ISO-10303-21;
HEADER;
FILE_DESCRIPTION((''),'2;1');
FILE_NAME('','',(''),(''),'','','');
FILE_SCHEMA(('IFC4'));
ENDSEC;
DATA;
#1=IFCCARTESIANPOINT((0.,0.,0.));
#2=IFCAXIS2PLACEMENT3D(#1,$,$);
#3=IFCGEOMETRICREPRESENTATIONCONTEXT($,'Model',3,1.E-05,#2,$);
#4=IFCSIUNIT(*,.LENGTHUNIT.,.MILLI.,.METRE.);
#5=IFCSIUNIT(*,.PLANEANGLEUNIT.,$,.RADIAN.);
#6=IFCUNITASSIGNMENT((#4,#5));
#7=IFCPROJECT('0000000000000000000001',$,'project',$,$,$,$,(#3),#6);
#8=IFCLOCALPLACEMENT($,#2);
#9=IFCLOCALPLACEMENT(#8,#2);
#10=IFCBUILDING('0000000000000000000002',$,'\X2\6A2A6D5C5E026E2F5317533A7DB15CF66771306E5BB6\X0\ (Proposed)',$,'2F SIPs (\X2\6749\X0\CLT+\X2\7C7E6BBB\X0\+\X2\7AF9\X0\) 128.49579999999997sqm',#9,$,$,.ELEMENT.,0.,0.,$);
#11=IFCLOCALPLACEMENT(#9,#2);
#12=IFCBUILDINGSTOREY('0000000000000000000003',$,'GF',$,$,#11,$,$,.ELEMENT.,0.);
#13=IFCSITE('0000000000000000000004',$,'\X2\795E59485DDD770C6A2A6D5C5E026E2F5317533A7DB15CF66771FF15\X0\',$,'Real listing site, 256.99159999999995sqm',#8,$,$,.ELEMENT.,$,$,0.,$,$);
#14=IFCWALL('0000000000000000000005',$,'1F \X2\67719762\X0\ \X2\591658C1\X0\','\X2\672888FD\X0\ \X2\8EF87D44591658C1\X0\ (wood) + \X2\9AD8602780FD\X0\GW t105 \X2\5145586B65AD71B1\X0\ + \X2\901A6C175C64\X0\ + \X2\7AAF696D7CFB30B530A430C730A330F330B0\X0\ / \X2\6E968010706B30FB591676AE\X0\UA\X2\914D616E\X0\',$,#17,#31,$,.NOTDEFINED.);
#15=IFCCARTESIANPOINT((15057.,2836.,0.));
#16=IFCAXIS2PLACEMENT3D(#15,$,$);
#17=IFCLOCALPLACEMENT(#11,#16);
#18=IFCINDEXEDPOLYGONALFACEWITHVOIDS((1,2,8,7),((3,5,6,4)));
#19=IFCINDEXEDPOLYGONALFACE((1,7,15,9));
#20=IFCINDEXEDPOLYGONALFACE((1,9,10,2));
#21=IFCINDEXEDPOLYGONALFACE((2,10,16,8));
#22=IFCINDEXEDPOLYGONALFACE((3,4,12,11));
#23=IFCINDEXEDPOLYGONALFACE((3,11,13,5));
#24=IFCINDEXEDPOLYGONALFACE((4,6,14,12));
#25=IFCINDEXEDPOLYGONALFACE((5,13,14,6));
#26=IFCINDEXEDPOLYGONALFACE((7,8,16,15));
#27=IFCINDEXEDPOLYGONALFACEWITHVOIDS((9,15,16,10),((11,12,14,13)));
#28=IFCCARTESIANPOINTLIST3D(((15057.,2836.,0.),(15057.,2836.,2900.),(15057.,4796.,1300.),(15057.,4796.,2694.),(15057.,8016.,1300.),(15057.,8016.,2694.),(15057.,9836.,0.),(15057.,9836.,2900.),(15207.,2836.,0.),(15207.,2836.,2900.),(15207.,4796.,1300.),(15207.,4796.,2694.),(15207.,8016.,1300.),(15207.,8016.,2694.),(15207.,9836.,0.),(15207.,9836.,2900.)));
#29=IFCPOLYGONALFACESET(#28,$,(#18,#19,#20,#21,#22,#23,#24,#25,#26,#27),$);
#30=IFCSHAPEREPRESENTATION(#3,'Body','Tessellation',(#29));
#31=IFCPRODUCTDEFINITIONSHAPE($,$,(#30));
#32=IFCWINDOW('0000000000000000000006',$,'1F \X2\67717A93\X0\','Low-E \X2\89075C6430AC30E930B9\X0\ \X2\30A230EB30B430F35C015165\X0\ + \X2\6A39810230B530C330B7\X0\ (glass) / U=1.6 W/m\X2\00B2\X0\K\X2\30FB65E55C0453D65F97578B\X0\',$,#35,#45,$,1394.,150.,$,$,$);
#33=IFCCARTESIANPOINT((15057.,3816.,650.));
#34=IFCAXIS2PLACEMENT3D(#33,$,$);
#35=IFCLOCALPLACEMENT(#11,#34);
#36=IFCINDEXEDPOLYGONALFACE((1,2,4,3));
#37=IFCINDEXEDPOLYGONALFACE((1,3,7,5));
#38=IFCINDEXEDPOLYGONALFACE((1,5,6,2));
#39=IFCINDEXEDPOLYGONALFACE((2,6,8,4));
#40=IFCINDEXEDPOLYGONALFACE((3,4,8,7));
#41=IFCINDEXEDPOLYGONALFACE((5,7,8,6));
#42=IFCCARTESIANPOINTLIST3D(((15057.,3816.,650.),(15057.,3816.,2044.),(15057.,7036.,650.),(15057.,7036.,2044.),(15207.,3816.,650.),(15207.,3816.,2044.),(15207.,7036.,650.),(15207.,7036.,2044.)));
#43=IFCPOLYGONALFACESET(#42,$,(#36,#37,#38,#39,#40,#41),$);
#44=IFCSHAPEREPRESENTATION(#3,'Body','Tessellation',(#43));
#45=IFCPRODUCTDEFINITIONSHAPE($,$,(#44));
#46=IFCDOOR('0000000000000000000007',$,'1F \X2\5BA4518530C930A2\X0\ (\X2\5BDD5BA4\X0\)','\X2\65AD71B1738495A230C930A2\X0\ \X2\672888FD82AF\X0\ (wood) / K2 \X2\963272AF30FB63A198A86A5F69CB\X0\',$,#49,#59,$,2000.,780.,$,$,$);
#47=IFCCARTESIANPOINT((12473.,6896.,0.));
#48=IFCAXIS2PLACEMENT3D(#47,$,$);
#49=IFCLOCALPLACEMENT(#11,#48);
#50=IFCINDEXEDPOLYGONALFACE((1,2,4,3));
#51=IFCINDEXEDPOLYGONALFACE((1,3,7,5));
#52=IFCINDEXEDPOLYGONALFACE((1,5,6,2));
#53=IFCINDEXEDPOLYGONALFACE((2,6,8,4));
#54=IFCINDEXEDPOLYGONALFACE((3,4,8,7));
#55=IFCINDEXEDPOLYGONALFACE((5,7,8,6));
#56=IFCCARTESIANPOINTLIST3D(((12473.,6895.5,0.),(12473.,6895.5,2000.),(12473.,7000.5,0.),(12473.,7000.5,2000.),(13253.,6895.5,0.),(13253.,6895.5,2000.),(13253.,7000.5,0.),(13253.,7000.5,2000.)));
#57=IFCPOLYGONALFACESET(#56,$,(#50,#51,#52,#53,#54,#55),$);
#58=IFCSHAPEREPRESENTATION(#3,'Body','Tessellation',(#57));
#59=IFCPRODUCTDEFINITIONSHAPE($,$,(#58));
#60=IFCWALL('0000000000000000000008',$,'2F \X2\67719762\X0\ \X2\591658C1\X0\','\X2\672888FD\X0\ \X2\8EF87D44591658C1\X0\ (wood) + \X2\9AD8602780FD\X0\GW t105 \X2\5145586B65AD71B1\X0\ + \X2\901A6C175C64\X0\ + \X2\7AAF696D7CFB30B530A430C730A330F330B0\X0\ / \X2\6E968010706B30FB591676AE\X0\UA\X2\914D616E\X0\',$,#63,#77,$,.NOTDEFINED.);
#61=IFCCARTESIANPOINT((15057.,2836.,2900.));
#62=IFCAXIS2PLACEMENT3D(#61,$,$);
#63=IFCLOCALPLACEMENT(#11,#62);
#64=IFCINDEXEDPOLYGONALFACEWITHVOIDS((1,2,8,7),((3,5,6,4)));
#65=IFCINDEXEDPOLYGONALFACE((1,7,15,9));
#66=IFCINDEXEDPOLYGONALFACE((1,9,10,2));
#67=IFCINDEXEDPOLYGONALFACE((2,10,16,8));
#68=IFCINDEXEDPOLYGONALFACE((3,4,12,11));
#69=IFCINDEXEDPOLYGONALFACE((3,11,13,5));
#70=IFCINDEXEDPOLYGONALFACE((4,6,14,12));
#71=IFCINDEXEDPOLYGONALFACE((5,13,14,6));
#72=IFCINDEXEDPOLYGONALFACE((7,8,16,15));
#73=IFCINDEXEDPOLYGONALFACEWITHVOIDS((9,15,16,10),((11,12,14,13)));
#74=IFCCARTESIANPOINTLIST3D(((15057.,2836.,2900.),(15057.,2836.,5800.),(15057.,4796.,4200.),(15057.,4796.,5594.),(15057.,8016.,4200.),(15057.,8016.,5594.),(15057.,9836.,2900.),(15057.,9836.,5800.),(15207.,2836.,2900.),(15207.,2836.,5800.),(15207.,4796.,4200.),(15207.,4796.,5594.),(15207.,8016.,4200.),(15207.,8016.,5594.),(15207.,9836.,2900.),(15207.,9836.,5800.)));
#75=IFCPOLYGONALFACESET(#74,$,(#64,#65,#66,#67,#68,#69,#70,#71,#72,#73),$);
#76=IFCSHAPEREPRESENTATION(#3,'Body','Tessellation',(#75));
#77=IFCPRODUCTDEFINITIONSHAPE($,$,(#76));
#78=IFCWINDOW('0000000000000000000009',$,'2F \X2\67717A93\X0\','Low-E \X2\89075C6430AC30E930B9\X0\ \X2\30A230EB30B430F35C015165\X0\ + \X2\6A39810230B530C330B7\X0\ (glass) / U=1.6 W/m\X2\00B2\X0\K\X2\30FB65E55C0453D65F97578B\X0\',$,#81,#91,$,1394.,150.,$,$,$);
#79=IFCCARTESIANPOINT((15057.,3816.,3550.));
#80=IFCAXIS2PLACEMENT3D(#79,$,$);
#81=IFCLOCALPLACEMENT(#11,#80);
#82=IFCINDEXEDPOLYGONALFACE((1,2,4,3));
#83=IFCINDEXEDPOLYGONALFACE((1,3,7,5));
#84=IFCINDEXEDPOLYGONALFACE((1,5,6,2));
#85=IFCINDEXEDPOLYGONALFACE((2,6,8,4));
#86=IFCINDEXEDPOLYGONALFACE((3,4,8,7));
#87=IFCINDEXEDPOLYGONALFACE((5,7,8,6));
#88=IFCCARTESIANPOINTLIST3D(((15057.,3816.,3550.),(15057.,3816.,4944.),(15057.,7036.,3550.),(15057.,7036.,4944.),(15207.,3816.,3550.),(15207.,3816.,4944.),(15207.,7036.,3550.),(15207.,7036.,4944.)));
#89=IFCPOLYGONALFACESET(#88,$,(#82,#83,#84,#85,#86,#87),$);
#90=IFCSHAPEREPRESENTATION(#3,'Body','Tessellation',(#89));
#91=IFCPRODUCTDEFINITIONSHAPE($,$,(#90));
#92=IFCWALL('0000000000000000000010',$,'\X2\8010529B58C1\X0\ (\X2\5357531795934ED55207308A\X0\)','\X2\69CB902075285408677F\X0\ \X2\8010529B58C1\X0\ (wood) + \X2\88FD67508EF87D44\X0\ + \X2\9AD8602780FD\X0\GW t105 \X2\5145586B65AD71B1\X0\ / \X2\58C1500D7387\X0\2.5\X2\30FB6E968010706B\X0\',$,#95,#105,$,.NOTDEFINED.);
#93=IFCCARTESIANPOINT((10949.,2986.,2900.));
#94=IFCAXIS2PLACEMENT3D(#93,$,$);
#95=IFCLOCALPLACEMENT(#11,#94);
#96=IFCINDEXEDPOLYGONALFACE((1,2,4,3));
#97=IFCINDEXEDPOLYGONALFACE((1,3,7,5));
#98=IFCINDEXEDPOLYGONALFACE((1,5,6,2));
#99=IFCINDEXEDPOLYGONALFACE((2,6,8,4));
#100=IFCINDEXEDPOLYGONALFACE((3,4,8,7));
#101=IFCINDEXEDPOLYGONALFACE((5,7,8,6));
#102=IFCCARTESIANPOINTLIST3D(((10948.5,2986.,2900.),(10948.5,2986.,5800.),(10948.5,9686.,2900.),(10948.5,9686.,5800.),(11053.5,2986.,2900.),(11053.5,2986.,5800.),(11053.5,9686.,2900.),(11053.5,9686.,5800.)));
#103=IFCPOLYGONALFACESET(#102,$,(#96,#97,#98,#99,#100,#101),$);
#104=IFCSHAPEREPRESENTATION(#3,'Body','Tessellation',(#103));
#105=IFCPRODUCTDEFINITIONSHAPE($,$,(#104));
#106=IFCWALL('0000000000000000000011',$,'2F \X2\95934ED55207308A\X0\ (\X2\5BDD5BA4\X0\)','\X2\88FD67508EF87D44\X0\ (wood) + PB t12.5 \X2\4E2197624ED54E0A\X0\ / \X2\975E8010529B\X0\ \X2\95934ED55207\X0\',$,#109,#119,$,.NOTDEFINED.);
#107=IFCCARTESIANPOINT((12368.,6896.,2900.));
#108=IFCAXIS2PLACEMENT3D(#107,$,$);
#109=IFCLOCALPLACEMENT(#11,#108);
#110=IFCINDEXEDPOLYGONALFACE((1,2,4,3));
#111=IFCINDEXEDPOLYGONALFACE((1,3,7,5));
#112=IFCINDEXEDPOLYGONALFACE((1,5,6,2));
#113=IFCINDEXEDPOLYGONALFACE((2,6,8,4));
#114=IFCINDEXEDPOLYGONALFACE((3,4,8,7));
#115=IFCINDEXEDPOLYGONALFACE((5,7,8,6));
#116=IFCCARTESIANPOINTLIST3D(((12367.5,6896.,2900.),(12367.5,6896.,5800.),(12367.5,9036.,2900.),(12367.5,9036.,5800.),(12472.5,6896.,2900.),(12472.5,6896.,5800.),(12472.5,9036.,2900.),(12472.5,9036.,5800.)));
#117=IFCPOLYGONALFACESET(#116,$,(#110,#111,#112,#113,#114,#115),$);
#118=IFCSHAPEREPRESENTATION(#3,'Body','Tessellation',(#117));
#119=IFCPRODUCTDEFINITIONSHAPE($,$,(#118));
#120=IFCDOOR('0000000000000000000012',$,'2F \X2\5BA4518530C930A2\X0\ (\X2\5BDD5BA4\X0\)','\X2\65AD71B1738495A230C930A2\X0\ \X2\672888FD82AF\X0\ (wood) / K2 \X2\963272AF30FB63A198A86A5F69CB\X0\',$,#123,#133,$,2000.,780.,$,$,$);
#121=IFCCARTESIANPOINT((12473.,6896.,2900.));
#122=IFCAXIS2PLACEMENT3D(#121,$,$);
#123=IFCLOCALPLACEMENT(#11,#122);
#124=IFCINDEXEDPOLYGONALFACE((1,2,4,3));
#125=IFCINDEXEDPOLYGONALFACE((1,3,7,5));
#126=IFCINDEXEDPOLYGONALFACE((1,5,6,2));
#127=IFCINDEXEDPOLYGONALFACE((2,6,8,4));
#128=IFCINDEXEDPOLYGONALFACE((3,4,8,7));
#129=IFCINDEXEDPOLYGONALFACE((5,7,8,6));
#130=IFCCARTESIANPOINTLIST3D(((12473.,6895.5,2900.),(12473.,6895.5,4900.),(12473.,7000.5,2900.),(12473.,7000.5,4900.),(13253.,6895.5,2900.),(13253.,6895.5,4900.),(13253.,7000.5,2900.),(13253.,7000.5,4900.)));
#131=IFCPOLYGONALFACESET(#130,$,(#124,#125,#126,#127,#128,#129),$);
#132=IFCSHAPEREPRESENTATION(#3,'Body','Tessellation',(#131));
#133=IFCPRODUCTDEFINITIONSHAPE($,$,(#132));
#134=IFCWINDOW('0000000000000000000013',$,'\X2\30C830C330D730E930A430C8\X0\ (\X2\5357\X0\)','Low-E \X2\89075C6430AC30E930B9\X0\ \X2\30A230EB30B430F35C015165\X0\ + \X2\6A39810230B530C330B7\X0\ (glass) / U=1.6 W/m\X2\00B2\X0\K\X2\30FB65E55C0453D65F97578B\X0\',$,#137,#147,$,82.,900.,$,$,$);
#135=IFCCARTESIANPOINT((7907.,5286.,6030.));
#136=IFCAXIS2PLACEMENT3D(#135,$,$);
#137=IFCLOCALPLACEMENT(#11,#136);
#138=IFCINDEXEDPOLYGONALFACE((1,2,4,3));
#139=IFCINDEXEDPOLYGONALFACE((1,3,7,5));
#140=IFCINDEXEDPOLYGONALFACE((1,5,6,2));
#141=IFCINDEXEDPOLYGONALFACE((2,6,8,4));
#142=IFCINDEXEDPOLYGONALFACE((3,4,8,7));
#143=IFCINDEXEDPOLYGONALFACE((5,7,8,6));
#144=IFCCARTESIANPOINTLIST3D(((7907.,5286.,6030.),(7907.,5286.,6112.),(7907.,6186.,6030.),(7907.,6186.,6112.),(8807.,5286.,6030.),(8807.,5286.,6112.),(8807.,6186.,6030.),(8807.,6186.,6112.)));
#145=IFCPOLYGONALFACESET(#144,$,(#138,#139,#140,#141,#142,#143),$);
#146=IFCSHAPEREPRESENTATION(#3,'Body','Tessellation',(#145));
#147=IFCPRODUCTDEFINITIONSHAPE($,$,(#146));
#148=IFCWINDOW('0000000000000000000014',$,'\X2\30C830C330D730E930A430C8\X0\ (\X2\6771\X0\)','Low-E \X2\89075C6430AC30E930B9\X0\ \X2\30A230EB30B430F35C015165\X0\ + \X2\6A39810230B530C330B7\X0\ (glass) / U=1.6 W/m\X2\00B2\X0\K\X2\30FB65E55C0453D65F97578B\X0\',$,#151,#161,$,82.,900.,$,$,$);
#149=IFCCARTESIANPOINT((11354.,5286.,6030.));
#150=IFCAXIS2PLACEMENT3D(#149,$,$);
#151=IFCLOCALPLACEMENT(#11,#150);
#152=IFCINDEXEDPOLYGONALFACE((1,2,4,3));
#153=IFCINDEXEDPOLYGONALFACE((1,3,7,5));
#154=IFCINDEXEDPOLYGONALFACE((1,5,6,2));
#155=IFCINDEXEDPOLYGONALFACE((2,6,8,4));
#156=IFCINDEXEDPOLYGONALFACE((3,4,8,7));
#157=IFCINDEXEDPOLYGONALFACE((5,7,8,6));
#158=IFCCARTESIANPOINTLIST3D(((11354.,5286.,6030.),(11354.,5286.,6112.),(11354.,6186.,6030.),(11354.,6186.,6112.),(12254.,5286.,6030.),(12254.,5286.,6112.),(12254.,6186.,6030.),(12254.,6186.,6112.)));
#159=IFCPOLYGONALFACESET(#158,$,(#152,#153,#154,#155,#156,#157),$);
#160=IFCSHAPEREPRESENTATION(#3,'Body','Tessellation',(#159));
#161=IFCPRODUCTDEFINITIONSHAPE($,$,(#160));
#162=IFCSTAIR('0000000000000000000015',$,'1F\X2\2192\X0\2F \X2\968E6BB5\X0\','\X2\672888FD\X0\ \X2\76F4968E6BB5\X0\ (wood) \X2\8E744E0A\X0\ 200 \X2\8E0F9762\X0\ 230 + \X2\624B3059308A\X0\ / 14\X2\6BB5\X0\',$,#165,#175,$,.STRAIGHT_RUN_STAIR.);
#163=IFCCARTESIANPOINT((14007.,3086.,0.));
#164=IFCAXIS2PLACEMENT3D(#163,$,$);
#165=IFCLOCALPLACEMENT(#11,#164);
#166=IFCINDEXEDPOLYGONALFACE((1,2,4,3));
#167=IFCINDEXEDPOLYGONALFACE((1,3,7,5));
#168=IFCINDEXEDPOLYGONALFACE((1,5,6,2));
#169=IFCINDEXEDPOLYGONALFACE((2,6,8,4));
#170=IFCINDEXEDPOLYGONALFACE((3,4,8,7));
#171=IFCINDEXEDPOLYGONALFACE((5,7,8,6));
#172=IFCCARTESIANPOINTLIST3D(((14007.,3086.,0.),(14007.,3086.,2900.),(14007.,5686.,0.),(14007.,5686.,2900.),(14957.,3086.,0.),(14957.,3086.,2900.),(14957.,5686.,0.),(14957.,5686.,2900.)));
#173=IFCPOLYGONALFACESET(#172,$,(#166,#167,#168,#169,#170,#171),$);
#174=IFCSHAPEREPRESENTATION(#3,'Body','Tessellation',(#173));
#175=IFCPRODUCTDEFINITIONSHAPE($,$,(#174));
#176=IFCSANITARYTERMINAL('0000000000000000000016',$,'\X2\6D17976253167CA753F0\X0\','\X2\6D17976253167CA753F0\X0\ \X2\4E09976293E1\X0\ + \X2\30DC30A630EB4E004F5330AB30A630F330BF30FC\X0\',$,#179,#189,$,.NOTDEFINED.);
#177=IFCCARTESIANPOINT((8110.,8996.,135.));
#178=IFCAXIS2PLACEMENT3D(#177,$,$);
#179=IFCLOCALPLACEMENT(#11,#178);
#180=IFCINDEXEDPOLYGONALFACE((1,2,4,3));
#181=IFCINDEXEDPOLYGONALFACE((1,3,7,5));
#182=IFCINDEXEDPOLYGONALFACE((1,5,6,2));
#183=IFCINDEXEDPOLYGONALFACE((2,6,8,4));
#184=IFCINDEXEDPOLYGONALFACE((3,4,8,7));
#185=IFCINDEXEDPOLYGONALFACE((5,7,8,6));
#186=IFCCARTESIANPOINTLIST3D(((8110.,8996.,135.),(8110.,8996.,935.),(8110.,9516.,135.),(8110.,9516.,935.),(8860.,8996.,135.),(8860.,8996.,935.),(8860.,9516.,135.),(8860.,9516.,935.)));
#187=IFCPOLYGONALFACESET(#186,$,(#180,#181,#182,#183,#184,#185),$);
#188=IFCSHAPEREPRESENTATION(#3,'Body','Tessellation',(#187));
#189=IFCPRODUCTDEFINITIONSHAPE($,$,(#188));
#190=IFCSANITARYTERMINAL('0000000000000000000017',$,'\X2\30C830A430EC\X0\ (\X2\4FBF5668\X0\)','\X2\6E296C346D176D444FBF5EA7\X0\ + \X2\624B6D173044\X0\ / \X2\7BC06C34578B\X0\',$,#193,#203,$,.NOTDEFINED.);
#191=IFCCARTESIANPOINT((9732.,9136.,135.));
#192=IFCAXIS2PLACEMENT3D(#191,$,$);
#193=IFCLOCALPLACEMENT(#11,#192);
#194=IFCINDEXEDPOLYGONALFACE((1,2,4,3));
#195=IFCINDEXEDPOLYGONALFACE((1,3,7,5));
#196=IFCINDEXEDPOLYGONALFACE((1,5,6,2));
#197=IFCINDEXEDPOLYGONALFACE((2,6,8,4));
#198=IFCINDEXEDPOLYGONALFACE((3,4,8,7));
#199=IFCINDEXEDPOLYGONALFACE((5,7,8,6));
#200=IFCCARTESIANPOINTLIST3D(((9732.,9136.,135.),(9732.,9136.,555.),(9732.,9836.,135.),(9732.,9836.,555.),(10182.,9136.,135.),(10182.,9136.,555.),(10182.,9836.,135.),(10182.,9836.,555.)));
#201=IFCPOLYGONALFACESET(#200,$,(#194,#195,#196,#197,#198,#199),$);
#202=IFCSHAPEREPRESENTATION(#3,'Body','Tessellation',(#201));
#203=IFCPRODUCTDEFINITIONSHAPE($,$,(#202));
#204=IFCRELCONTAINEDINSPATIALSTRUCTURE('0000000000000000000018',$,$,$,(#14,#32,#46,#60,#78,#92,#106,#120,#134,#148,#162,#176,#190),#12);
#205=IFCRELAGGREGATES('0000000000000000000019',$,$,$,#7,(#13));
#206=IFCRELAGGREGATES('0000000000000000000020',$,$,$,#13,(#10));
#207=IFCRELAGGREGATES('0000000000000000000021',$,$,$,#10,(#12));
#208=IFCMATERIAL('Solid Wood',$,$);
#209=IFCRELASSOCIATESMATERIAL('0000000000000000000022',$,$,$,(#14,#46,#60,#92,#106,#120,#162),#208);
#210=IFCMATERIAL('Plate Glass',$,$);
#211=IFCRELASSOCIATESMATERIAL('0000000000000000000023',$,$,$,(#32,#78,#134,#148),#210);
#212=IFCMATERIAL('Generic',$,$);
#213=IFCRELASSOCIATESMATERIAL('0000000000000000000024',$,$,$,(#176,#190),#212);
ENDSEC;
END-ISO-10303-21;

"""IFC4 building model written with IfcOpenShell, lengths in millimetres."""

from ifc_helpers import new_model, si_unit, frame, frame_2d, origin, place, context, project, spatial, rectangle, extrude, material, element, fill, save


model = new_model("IFC4")

# Units and contexts
model_context = context("Model", 3, precision=1e-05, world=origin())
ifc_project = project(units=[si_unit("LENGTHUNIT", "METRE", prefix="MILLI"), si_unit("PLANEANGLEUNIT", "RADIAN")], contexts=[model_context])

# Site, building, storey
site_placement = place(None, origin())
site = spatial("IfcSite", under=ifc_project, at=site_placement, Name="神奈川県横浜市港北区綱島東５", ObjectType="Real listing site, 256.99159999999995sqm", CompositionType="ELEMENT", RefElevation=0.0)
building_placement = place(site_placement, origin())
building = spatial("IfcBuilding", under=site, at=building_placement, Name="横浜市港北区綱島東の家 (Proposed)", ObjectType="2F SIPs (杉CLT+籾殻+竹) 128.49579999999997sqm", CompositionType="ELEMENT", ElevationOfRefHeight=0.0, ElevationOfTerrain=0.0)
storey_placement = place(building_placement, origin())
storey = spatial("IfcBuildingStorey", under=building, at=storey_placement, Name="GF", CompositionType="ELEMENT", Elevation=0.0)

# Wall, opening, window
ifc_material_1 = material(Name="Solid Wood")
wall_1_placement = place(storey_placement, frame((15057.0, 2836.0, 0.0)))
wall_1 = element("IfcWall", 1, at=wall_1_placement, inside=storey, material=ifc_material_1, Name="1F 東面 外壁", Description="木製 軸組外壁 (wood) + 高性能GW t105 充填断熱 + 通気層 + 窯業系サイディング / 準耐火・外皮UA配慮", PredefinedType="NOTDEFINED", context=model_context, shape_type="SweptSolid", body=[
    extrude(rectangle(XDim=150.0, YDim=7000.0, at=frame_2d((75.0, 3500.0))), frame((15057.0, 2836.0, 0.0)), (0.0, 0.0, 1.0), 2900.0),
])
opening_1_placement = place(storey_placement, frame((15057.0, 3816.0, 650.0)))
opening_1 = element("IfcOpeningElement", 2, at=opening_1_placement, cuts=wall_1, PredefinedType="NOTDEFINED", context=model_context, shape_type="SweptSolid", body=[
    extrude(rectangle(XDim=150.0, YDim=3220.0, at=frame_2d((75.0, 1610.0))), frame((15057.0, 3816.0, 650.0)), (0.0, 0.0, 1.0), 1394.0),
])
ifc_material_2 = material(Name="Plate Glass")
window_1_placement = place(storey_placement, frame((15057.0, 3816.0, 650.0)))
window_1 = element("IfcWindow", 3, at=window_1_placement, inside=storey, material=ifc_material_2, Name="1F 東窓", Description="Low-E 複層ガラス アルゴン封入 + 樹脂サッシ (glass) / U=1.6 W/m²K・日射取得型", OverallHeight=1394.0, OverallWidth=150.0, context=model_context, shape_type="SweptSolid", body=[
    extrude(rectangle(XDim=150.0, YDim=3220.0, at=frame_2d((75.0, 1610.0))), frame((15057.0, 3816.0, 650.0)), (0.0, 0.0, 1.0), 1394.0),
])
fill(opening_1, window_1)

# Door
door_1_placement = place(storey_placement, frame((12473.0, 6896.0, 0.0)))
element("IfcDoor", 4, at=door_1_placement, inside=storey, material=ifc_material_1, Name="1F 室内ドア (寝室)", Description="断熱玄関ドア 木製芯 (wood) / K2 防犯・採風機構", OverallHeight=2000.0, OverallWidth=780.0, context=model_context, shape_type="SweptSolid", body=[
    extrude(rectangle(XDim=780.0, YDim=105.0, at=frame_2d((390.0, 52.0))), frame((12473.0, 6896.0, 0.0)), (0.0, 0.0, 1.0), 2000.0),
])

# Wall, opening, window
wall_2_placement = place(storey_placement, frame((15057.0, 2836.0, 2900.0)))
wall_2 = element("IfcWall", 5, at=wall_2_placement, inside=storey, material=ifc_material_1, Name="2F 東面 外壁", Description="木製 軸組外壁 (wood) + 高性能GW t105 充填断熱 + 通気層 + 窯業系サイディング / 準耐火・外皮UA配慮", PredefinedType="NOTDEFINED", context=model_context, shape_type="SweptSolid", body=[
    extrude(rectangle(XDim=150.0, YDim=7000.0, at=frame_2d((75.0, 3500.0))), frame((15057.0, 2836.0, 2900.0)), (0.0, 0.0, 1.0), 2900.0),
])
opening_2_placement = place(storey_placement, frame((15057.0, 3816.0, 3550.0)))
opening_2 = element("IfcOpeningElement", 6, at=opening_2_placement, cuts=wall_2, PredefinedType="NOTDEFINED", context=model_context, shape_type="SweptSolid", body=[
    extrude(rectangle(XDim=150.0, YDim=3220.0, at=frame_2d((75.0, 1610.0))), frame((15057.0, 3816.0, 3550.0)), (0.0, 0.0, 1.0), 1394.0),
])
window_2_placement = place(storey_placement, frame((15057.0, 3816.0, 3550.0)))
window_2 = element("IfcWindow", 7, at=window_2_placement, inside=storey, material=ifc_material_2, Name="2F 東窓", Description="Low-E 複層ガラス アルゴン封入 + 樹脂サッシ (glass) / U=1.6 W/m²K・日射取得型", OverallHeight=1394.0, OverallWidth=150.0, context=model_context, shape_type="SweptSolid", body=[
    extrude(rectangle(XDim=150.0, YDim=3220.0, at=frame_2d((75.0, 1610.0))), frame((15057.0, 3816.0, 3550.0)), (0.0, 0.0, 1.0), 1394.0),
])
fill(opening_2, window_2)

# Walls
wall_3_placement = place(storey_placement, frame((10949.0, 2986.0, 2900.0)))
element("IfcWall", 8, at=wall_3_placement, inside=storey, material=ifc_material_1, Name="耐力壁 (南北間仕切り)", Description="構造用合板 耐力壁 (wood) + 製材軸組 + 高性能GW t105 充填断熱 / 壁倍率2.5・準耐火", PredefinedType="NOTDEFINED", context=model_context, shape_type="SweptSolid", body=[
    extrude(rectangle(XDim=105.0, YDim=6700.0, at=frame_2d((52.0, 3350.0))), frame((10949.0, 2986.0, 2900.0)), (0.0, 0.0, 1.0), 2900.0),
])
wall_4_placement = place(storey_placement, frame((12368.0, 6896.0, 2900.0)))
element("IfcWall", 9, at=wall_4_placement, inside=storey, material=ifc_material_1, Name="2F 間仕切り (寝室)", Description="製材軸組 (wood) + PB t12.5 両面仕上 / 非耐力 間仕切", PredefinedType="NOTDEFINED", context=model_context, shape_type="SweptSolid", body=[
    extrude(rectangle(XDim=105.0, YDim=2140.0, at=frame_2d((52.0, 1070.0))), frame((12368.0, 6896.0, 2900.0)), (0.0, 0.0, 1.0), 2900.0),
])

# Door
door_2_placement = place(storey_placement, frame((12473.0, 6896.0, 2900.0)))
element("IfcDoor", 10, at=door_2_placement, inside=storey, material=ifc_material_1, Name="2F 室内ドア (寝室)", Description="断熱玄関ドア 木製芯 (wood) / K2 防犯・採風機構", OverallHeight=2000.0, OverallWidth=780.0, context=model_context, shape_type="SweptSolid", body=[
    extrude(rectangle(XDim=780.0, YDim=105.0, at=frame_2d((390.0, 52.0))), frame((12473.0, 6896.0, 2900.0)), (0.0, 0.0, 1.0), 2000.0),
])

# Windows
window_3_placement = place(storey_placement, frame((7907.0, 5286.0, 6030.0)))
element("IfcWindow", 11, at=window_3_placement, inside=storey, material=ifc_material_2, Name="トップライト (南)", Description="Low-E 複層ガラス アルゴン封入 + 樹脂サッシ (glass) / U=1.6 W/m²K・日射取得型", OverallHeight=82.0, OverallWidth=900.0, context=model_context, shape_type="SweptSolid", body=[
    extrude(rectangle(XDim=900.0, YDim=900.0, at=frame_2d((450.0, 450.0))), frame((7907.0, 5286.0, 6030.0)), (0.0, 0.0, 1.0), 82.0),
])
window_4_placement = place(storey_placement, frame((11354.0, 5286.0, 6030.0)))
element("IfcWindow", 12, at=window_4_placement, inside=storey, material=ifc_material_2, Name="トップライト (東)", Description="Low-E 複層ガラス アルゴン封入 + 樹脂サッシ (glass) / U=1.6 W/m²K・日射取得型", OverallHeight=82.0, OverallWidth=900.0, context=model_context, shape_type="SweptSolid", body=[
    extrude(rectangle(XDim=900.0, YDim=900.0, at=frame_2d((450.0, 450.0))), frame((11354.0, 5286.0, 6030.0)), (0.0, 0.0, 1.0), 82.0),
])

# Stair
stair_placement = place(storey_placement, frame((14007.0, 3086.0, 0.0)))
element("IfcStair", 13, at=stair_placement, inside=storey, material=ifc_material_1, Name="1F→2F 階段", Description="木製 直階段 (wood) 蹴上 200 踏面 230 + 手すり / 14段", PredefinedType="STRAIGHT_RUN_STAIR", context=model_context, shape_type="SweptSolid", body=[
    extrude(rectangle(XDim=950.0, YDim=2600.0, at=frame_2d((475.0, 1300.0))), frame((14007.0, 3086.0, 0.0)), (0.0, 0.0, 1.0), 2900.0),
])

# Sanitary terminals
ifc_material_3 = material(Name="Generic")
sanitary_terminal_1_placement = place(storey_placement, frame((8110.0, 8996.0, 135.0)))
element("IfcSanitaryTerminal", 14, at=sanitary_terminal_1_placement, inside=storey, material=ifc_material_3, Name="洗面化粧台", Description="洗面化粧台 三面鏡 + ボウル一体カウンター", PredefinedType="NOTDEFINED", context=model_context, shape_type="SweptSolid", body=[
    extrude(rectangle(XDim=750.0, YDim=520.0, at=frame_2d((375.0, 260.0))), frame((8110.0, 8996.0, 135.0)), (0.0, 0.0, 1.0), 800.0),
])
sanitary_terminal_2_placement = place(storey_placement, frame((9732.0, 9136.0, 135.0)))
element("IfcSanitaryTerminal", 15, at=sanitary_terminal_2_placement, inside=storey, material=ifc_material_3, Name="トイレ (便器)", Description="温水洗浄便座 + 手洗い / 節水型", PredefinedType="NOTDEFINED", context=model_context, shape_type="SweptSolid", body=[
    extrude(rectangle(XDim=450.0, YDim=700.0, at=frame_2d((225.0, 350.0))), frame((9732.0, 9136.0, 135.0)), (0.0, 0.0, 1.0), 420.0),
])

save(model, "model.ifc")
